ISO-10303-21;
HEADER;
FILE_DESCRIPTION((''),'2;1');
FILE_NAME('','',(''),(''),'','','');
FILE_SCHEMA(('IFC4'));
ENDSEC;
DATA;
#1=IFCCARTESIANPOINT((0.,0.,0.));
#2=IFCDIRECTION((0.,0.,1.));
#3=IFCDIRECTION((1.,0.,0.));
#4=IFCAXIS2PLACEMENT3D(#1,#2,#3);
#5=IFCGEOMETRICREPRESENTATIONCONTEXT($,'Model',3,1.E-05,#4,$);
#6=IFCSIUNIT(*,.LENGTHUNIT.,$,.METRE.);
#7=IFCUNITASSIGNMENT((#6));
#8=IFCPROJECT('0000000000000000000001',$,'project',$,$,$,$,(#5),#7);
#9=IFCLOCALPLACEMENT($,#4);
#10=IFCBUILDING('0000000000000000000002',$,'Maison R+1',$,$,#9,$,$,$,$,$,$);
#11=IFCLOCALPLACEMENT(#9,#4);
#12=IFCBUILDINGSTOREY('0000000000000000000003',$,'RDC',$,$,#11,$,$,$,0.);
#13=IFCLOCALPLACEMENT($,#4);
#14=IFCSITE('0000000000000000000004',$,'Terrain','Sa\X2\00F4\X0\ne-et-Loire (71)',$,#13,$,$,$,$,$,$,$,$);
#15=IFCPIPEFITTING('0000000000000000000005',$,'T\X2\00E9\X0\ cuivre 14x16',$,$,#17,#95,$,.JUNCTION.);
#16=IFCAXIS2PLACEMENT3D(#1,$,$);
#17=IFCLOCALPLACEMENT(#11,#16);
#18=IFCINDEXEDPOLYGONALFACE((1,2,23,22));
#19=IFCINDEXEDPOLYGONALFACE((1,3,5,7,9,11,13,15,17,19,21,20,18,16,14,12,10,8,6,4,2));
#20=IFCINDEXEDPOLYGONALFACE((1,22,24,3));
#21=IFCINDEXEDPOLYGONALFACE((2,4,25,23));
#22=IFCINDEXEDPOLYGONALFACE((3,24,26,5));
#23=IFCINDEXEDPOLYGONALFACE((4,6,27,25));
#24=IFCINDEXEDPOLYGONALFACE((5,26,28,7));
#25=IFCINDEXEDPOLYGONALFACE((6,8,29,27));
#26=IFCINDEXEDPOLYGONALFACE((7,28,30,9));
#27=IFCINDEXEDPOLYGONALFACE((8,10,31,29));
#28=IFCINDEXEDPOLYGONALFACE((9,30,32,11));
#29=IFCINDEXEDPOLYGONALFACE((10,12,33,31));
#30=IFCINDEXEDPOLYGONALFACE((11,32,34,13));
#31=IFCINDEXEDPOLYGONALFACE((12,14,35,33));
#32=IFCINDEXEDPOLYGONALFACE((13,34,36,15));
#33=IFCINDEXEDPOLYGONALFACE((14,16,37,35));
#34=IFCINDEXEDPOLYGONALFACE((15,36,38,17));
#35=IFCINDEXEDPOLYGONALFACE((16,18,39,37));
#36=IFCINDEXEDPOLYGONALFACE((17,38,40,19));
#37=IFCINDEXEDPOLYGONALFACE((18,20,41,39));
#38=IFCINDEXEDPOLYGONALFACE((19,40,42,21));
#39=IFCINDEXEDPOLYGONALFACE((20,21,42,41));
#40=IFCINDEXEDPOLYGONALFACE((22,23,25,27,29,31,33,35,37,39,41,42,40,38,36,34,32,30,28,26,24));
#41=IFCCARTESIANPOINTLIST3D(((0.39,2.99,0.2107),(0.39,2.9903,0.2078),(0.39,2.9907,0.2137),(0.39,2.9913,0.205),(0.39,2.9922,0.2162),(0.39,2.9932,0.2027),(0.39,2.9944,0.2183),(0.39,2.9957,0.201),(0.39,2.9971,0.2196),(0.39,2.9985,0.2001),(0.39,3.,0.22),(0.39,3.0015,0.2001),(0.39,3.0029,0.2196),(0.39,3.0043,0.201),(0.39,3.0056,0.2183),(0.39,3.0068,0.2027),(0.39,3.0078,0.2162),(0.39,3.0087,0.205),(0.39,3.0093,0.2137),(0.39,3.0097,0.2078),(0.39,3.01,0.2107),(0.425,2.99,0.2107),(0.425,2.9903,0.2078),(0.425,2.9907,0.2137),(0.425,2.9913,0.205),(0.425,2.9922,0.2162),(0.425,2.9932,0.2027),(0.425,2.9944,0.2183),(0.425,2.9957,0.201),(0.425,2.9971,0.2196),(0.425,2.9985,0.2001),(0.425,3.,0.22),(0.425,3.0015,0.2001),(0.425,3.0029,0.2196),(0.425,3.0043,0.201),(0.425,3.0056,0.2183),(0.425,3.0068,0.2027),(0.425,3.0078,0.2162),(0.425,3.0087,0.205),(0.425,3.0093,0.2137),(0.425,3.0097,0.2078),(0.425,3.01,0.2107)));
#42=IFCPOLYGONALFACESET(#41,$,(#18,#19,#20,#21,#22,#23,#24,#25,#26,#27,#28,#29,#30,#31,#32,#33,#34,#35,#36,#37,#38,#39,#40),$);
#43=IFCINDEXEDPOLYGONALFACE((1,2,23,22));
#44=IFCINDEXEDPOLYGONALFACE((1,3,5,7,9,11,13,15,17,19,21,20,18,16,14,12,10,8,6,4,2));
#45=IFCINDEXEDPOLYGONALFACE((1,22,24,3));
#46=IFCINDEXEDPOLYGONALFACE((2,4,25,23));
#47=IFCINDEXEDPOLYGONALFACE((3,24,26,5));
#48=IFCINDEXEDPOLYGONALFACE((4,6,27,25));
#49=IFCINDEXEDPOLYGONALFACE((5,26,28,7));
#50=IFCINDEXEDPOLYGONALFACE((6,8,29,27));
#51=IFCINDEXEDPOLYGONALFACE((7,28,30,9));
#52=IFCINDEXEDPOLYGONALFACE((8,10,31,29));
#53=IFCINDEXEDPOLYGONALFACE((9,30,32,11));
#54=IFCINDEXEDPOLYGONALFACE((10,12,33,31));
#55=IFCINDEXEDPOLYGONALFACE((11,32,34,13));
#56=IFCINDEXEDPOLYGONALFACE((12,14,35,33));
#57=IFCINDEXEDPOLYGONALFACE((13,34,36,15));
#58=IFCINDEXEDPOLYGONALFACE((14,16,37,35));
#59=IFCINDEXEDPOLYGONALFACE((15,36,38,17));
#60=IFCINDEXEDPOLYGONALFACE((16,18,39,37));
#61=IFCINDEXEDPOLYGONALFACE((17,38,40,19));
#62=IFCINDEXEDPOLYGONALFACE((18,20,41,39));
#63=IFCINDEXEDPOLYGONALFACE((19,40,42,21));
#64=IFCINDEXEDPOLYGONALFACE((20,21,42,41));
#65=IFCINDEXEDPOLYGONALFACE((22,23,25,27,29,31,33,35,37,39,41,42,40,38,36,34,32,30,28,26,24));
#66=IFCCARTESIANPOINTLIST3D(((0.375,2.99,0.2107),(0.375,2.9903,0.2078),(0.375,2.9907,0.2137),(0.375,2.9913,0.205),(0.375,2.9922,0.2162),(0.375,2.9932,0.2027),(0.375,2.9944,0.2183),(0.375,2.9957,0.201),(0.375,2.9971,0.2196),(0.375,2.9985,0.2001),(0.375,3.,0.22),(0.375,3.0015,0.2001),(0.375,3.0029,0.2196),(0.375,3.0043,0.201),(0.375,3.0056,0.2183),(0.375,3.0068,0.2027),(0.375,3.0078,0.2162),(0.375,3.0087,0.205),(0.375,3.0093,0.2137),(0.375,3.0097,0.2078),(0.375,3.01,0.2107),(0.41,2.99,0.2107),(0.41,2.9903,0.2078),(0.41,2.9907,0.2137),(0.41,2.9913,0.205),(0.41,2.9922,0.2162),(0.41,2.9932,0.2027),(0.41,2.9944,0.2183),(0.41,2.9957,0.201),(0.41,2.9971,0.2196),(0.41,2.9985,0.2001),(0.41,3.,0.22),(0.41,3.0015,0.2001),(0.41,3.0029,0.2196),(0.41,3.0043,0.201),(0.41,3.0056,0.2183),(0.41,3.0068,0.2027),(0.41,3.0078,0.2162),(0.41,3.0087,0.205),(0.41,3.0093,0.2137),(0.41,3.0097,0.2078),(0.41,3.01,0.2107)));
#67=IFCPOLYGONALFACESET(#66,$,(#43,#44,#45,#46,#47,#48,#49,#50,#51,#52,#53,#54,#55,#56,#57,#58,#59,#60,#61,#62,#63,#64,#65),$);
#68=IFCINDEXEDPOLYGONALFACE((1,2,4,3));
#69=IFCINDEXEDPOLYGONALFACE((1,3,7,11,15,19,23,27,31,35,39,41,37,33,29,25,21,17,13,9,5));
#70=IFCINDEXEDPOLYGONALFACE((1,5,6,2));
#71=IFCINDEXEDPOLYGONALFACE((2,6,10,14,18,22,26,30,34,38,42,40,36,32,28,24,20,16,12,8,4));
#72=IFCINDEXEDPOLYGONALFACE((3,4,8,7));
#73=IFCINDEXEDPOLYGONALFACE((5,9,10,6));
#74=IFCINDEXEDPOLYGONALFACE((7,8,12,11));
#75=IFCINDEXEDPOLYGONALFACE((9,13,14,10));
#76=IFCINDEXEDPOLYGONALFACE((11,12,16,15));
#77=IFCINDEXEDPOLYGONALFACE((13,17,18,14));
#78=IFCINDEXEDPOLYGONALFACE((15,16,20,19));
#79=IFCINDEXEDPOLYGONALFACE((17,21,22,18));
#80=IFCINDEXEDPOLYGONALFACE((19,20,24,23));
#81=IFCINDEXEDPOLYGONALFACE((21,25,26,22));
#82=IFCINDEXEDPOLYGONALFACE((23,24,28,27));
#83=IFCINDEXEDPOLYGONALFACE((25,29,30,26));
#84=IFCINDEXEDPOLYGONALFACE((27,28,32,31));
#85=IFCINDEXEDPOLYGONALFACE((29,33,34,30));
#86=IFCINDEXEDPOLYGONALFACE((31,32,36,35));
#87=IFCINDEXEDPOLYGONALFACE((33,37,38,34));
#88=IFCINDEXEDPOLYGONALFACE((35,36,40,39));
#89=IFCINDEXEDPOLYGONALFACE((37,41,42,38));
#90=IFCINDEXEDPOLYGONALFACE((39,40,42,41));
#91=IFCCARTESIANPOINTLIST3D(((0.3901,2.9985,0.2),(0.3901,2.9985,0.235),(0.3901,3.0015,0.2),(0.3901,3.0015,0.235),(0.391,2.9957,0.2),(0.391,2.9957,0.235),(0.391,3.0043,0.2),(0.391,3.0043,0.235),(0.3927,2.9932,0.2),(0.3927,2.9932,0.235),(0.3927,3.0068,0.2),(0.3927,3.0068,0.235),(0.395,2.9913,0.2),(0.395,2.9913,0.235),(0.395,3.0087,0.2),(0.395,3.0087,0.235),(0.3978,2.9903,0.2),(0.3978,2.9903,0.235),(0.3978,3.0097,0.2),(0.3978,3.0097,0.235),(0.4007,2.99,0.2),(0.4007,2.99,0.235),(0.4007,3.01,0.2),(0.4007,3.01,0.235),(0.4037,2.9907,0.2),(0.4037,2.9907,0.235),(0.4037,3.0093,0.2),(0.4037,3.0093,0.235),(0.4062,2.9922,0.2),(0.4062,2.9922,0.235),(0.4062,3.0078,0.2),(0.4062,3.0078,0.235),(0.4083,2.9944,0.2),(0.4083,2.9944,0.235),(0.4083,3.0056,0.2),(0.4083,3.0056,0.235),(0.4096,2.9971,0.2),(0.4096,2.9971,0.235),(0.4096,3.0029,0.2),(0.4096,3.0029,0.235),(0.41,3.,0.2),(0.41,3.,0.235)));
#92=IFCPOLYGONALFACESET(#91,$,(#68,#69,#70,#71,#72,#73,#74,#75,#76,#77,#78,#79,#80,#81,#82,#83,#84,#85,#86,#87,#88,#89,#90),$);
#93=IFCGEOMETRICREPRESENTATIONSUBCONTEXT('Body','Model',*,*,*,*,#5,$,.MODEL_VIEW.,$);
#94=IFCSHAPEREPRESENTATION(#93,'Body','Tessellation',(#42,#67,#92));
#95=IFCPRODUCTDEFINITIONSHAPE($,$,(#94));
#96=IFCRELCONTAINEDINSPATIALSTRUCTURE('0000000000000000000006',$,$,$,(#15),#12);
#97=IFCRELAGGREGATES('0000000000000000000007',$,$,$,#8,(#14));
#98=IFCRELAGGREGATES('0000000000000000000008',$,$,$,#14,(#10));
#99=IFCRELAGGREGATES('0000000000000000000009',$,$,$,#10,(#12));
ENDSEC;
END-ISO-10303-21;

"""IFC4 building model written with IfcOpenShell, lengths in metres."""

from ifc_helpers import new_model, si_unit, frame, origin_with_axes, place, context, subcontext, project, spatial, circle, extrude, element, save


model = new_model("IFC4")

# Units and contexts
model_context = context("Model", 3, precision=1e-05, world=origin_with_axes())
body_context = subcontext(model_context, "Body", "Model", "MODEL_VIEW")
ifc_project = project(units=[si_unit("LENGTHUNIT", "METRE")], contexts=[model_context])

# Site, building, storey
site_placement = place(None, origin_with_axes())
site = spatial("IfcSite", under=ifc_project, at=site_placement, Name="Terrain", Description="Saône-et-Loire (71)")
building_placement = place(None, origin_with_axes())
building = spatial("IfcBuilding", under=site, at=building_placement, Name="Maison R+1")
storey_placement = place(building_placement, origin_with_axes())
storey = spatial("IfcBuildingStorey", under=building, at=storey_placement, Name="RDC", Elevation=0.0)

# Pipe fitting
pipe_fitting_placement = place(storey_placement, frame((0.4, 3.0, 0.21), z_axis=(0.0, 0.0, 1.0), x_axis=(1.0, 0.0, 0.0)))
element("IfcPipeFitting", 1, at=pipe_fitting_placement, inside=storey, Name="Té cuivre 14x16", PredefinedType="JUNCTION", context=body_context, shape_type="SweptSolid", body=[
    extrude(circle(Radius=0.01), frame((-0.01, 0.0, 0.0), z_axis=(1.0, 0.0, 0.0), x_axis=(0.0, 0.0, 1.0)), (0.0, 0.0, 1.0), 0.035),
    extrude(circle(Radius=0.01), frame((0.01, 0.0, 0.0), z_axis=(-1.0, 0.0, 0.0), x_axis=(0.0, 0.0, 1.0)), (0.0, 0.0, 1.0), 0.035),
    extrude(circle(Radius=0.01), frame((0.0, 0.0, -0.01), z_axis=(0.0, 0.0, 1.0), x_axis=(1.0, 0.0, 0.0)), (0.0, 0.0, 1.0), 0.035),
])

save(model, "model.ifc")
